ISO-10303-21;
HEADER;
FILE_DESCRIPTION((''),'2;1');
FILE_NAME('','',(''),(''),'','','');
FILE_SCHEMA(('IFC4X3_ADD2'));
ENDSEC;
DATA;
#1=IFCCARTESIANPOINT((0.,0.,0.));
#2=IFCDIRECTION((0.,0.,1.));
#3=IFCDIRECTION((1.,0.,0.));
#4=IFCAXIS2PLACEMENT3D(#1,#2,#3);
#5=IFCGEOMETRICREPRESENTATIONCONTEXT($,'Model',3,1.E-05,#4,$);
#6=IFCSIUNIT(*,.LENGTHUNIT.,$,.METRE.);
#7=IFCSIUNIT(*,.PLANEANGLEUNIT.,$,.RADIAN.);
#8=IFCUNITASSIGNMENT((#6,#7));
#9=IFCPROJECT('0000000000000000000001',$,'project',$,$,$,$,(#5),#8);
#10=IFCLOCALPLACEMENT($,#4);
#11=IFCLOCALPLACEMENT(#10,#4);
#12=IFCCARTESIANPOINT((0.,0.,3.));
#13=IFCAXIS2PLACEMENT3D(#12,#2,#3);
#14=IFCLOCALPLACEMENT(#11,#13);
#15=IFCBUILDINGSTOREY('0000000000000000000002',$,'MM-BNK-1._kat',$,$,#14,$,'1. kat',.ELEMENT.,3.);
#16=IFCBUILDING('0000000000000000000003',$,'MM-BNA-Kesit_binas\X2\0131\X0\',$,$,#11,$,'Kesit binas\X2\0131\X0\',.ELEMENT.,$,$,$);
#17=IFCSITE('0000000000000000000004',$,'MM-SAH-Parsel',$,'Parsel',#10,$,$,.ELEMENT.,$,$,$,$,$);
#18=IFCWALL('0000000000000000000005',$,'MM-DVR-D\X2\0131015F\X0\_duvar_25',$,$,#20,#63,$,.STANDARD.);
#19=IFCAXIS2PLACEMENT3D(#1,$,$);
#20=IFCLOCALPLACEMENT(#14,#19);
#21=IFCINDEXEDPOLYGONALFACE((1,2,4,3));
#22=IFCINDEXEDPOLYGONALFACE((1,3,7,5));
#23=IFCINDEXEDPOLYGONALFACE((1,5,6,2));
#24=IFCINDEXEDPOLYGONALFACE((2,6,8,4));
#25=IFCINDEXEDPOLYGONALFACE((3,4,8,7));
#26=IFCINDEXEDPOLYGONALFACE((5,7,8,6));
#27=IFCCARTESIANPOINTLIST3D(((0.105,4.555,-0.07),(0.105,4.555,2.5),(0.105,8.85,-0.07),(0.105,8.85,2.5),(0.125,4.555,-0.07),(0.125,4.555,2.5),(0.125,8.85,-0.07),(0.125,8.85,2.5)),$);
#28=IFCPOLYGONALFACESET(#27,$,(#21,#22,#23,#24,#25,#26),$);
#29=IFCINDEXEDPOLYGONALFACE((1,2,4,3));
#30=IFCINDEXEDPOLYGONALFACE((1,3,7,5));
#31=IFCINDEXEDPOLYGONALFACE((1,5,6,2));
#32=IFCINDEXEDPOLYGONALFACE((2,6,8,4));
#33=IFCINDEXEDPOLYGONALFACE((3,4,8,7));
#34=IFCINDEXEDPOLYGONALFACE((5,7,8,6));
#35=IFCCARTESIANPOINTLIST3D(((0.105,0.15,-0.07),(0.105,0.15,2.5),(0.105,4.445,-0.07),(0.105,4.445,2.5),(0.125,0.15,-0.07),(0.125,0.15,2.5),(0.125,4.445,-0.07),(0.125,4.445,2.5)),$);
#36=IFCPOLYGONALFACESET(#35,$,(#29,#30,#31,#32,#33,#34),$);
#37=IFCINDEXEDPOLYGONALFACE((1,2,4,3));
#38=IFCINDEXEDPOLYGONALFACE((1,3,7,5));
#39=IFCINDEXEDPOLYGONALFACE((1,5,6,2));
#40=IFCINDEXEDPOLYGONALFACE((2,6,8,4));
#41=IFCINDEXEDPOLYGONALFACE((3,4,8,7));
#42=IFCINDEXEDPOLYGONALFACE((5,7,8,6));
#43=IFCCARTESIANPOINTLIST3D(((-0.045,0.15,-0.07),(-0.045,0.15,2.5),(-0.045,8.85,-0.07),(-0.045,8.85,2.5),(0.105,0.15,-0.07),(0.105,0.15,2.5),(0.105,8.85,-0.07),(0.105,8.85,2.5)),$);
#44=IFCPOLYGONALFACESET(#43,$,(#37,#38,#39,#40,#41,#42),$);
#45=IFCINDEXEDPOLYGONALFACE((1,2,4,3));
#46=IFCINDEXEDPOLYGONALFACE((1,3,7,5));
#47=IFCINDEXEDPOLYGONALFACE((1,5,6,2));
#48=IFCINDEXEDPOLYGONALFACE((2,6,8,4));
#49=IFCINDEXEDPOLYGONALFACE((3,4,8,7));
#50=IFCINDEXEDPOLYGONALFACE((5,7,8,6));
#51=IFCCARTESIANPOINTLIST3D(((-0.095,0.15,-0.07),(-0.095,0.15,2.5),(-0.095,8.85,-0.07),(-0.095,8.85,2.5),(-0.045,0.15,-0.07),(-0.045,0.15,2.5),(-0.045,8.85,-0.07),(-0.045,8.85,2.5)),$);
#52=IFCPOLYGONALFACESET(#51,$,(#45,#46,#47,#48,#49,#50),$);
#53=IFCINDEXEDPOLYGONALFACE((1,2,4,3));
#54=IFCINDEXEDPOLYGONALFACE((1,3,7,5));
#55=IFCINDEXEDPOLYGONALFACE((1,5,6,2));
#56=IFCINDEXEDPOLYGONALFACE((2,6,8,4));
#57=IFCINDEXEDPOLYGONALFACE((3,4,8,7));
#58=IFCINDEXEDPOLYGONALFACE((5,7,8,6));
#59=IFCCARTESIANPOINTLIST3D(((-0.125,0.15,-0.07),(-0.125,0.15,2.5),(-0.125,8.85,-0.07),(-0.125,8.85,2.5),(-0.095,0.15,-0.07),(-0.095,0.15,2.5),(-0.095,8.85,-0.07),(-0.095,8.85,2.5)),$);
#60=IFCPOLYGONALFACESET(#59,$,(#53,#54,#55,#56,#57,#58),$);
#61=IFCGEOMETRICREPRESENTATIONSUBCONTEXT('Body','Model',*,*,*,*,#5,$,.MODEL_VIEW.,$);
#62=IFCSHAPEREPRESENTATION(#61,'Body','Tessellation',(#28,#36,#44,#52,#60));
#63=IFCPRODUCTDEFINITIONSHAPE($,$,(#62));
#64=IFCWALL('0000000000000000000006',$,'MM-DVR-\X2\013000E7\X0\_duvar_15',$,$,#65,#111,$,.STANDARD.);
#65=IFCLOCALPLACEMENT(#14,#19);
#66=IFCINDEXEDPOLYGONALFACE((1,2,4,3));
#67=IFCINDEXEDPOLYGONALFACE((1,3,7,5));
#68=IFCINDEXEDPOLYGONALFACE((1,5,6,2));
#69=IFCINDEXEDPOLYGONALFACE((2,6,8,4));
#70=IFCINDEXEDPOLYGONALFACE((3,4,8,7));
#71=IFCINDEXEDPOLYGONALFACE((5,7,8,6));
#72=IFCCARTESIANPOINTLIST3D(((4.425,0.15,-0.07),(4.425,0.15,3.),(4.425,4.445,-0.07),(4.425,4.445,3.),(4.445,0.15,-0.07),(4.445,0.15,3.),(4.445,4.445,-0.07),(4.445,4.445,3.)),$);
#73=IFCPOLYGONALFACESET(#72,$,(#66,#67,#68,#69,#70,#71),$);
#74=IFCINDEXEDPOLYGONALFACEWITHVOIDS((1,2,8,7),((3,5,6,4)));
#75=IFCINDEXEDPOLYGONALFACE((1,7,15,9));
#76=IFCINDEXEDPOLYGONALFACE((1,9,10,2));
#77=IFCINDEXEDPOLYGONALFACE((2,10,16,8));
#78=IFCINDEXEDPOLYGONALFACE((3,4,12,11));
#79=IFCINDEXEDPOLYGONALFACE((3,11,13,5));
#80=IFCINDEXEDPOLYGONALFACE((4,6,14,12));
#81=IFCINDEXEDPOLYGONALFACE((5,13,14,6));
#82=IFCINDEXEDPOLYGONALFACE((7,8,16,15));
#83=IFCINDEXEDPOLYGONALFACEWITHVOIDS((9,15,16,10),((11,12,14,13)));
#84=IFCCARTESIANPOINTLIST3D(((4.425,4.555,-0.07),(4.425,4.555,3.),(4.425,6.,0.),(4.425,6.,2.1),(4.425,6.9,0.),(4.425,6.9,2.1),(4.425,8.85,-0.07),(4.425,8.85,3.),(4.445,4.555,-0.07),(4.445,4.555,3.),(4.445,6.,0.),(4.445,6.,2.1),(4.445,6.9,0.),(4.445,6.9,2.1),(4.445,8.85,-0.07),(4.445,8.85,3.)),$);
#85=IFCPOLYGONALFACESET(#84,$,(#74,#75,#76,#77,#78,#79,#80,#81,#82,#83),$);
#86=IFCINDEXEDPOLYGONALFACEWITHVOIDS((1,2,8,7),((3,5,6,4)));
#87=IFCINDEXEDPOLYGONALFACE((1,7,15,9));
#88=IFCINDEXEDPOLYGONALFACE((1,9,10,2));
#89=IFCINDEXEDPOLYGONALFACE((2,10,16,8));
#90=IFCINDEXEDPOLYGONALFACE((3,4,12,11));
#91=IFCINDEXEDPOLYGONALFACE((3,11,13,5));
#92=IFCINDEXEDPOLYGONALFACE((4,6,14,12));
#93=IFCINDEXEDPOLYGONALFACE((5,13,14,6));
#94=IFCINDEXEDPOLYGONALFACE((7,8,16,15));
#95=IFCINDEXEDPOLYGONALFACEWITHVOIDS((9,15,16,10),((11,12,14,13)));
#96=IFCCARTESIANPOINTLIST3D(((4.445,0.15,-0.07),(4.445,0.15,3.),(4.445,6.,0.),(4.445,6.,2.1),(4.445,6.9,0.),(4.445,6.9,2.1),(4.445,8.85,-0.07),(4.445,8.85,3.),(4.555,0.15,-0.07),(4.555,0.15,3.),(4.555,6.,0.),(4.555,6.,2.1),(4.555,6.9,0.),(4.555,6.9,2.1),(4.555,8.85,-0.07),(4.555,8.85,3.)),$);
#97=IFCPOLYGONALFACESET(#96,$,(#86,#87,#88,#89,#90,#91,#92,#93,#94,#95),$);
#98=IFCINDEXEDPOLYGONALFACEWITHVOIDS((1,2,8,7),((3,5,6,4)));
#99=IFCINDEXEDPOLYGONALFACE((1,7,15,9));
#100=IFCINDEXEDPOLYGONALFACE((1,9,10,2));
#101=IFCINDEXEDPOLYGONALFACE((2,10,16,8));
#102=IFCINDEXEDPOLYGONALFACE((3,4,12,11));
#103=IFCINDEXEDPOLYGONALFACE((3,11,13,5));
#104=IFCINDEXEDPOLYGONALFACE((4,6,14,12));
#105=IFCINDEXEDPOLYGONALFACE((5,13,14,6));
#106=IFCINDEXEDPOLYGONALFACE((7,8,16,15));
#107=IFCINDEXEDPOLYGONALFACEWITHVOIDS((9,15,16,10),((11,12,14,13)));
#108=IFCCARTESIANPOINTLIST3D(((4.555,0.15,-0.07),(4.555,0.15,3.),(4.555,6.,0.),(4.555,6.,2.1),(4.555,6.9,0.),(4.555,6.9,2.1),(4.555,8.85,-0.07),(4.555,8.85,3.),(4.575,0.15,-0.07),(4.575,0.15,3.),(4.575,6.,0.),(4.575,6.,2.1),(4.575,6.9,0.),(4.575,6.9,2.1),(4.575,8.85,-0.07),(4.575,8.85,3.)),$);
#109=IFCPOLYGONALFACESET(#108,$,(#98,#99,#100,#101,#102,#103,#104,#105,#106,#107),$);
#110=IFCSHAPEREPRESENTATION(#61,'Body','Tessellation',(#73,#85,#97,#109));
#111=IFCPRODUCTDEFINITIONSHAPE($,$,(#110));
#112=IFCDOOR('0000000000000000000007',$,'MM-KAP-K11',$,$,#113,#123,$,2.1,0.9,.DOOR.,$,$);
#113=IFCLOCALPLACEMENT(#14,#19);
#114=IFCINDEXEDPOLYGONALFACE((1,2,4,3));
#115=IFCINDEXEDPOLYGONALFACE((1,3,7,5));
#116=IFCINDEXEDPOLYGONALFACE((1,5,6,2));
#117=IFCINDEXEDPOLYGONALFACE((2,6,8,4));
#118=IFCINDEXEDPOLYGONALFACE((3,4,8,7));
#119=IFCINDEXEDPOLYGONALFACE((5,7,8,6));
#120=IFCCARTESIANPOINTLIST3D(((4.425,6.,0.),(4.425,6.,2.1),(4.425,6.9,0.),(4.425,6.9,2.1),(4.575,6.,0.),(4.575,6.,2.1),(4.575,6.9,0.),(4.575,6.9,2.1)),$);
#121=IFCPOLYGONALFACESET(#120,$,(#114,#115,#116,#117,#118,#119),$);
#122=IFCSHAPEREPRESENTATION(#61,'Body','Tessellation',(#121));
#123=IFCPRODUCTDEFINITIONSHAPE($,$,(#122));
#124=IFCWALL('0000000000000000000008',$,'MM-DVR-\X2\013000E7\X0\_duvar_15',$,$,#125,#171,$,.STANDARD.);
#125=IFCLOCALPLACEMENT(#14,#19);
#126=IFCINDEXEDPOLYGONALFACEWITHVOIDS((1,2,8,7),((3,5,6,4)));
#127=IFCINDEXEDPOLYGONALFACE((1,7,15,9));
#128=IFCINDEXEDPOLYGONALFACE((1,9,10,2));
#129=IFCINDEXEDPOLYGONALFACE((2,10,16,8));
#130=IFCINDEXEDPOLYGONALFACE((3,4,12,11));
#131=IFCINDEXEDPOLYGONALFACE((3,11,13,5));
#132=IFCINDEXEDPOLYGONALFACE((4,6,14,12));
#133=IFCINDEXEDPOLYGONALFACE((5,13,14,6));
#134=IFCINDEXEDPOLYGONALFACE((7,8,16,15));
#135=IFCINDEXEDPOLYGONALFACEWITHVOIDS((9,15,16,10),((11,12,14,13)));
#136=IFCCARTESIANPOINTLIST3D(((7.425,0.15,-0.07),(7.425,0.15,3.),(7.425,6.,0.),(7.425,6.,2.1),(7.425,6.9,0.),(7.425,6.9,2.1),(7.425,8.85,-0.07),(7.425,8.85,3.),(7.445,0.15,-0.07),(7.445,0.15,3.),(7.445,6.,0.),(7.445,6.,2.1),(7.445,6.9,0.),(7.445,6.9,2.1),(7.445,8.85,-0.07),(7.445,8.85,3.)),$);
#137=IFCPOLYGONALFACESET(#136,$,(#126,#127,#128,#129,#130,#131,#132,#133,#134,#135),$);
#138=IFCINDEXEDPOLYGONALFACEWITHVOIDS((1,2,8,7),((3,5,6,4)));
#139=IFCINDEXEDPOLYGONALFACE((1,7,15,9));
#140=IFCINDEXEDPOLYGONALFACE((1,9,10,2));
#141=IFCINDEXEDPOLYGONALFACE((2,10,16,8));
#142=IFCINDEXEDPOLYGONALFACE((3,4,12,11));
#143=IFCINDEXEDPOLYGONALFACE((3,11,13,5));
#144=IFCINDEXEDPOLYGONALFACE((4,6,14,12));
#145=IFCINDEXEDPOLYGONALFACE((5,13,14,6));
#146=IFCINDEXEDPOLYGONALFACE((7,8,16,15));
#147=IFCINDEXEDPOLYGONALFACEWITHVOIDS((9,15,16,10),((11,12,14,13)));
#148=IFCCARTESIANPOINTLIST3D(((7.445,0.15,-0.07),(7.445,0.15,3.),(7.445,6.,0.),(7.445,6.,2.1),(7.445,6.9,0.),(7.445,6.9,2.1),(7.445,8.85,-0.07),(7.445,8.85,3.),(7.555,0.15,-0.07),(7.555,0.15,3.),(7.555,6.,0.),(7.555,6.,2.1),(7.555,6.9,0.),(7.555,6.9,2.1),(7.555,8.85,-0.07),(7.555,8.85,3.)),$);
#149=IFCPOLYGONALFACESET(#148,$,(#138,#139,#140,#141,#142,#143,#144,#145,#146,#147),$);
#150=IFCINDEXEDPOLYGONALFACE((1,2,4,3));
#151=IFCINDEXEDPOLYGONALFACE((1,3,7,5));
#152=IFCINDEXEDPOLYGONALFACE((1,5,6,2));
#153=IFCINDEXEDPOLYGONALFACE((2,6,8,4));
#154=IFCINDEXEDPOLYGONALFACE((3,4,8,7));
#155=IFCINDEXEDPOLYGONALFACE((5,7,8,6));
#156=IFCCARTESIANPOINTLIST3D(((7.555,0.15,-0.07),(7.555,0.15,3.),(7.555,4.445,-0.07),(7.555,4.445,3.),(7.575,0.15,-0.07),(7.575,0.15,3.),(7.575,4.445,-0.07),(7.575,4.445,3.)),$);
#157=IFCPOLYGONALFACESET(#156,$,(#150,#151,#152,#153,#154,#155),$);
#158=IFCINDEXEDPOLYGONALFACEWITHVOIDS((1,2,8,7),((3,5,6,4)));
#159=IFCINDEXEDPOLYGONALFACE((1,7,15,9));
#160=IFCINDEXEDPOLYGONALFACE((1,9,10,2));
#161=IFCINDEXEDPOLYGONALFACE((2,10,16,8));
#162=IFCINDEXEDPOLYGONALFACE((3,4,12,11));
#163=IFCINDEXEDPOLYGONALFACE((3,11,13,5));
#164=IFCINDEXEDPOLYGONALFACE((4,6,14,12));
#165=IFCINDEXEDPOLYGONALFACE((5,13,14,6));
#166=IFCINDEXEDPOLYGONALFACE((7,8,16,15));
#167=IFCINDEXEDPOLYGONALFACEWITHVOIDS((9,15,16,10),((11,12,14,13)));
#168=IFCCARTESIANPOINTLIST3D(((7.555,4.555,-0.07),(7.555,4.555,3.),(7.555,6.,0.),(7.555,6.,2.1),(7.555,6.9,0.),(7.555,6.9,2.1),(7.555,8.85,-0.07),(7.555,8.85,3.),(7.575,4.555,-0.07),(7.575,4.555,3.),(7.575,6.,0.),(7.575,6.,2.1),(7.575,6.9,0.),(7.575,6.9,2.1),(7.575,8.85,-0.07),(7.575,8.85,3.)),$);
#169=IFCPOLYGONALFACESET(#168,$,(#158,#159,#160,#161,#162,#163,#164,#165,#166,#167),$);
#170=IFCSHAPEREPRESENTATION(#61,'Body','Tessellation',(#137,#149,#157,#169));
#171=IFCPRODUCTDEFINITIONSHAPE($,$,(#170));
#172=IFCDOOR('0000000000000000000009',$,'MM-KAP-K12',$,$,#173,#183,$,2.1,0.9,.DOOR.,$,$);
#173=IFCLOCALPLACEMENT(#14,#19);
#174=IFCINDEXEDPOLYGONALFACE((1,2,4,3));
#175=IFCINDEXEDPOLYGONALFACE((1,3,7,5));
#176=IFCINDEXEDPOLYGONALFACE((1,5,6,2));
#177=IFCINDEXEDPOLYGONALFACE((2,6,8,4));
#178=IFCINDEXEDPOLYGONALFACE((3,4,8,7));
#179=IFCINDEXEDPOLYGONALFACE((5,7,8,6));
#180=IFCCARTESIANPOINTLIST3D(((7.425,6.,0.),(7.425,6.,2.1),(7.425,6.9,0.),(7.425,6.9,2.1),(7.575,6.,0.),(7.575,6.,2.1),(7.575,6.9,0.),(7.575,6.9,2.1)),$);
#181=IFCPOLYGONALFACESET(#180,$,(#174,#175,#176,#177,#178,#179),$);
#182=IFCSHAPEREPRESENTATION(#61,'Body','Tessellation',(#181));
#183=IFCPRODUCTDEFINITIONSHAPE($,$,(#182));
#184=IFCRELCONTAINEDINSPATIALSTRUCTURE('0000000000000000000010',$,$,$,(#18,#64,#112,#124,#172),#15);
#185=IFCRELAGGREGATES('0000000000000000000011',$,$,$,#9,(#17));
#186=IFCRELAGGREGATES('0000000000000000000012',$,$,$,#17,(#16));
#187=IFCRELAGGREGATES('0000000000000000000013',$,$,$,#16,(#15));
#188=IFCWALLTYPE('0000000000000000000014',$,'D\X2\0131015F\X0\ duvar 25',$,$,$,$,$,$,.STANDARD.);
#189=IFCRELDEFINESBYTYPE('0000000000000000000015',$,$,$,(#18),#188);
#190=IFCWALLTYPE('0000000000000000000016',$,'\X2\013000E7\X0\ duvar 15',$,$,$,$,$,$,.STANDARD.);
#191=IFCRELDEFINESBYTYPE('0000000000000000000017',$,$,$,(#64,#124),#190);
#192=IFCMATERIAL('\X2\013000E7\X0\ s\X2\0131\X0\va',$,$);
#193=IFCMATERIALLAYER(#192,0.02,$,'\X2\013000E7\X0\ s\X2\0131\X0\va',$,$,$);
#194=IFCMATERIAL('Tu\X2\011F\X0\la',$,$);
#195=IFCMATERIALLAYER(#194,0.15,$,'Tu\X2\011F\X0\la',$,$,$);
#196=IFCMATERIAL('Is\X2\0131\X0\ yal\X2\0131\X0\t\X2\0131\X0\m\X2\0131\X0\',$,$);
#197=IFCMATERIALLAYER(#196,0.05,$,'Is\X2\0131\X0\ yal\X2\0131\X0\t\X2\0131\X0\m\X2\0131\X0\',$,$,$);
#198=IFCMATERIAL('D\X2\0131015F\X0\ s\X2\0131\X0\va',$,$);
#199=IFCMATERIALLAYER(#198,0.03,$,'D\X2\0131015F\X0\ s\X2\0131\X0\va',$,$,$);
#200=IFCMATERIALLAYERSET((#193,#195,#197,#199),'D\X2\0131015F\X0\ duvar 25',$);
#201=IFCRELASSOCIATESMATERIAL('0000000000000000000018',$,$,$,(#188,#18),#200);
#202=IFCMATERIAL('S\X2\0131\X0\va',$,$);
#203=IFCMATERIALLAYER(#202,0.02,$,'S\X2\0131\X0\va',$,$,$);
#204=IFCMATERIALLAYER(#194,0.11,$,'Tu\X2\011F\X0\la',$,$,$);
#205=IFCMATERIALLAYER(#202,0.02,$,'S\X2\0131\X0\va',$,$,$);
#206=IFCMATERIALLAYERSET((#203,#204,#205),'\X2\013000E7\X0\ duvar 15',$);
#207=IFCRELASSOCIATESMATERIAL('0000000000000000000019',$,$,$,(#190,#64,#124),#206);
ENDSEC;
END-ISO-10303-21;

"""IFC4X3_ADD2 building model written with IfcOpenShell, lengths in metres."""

from ifc_helpers import new_model, si_unit, frame, origin, origin_with_axes, place, context, subcontext, project, spatial, polyline, outline, extrude, material, layer, layer_set, type_object, element, fill, save


model = new_model("IFC4X3_ADD2")

# Units and contexts
model_context = context("Model", 3, precision=1e-05, world=origin_with_axes())
body_context = subcontext(model_context, "Body", "Model", "MODEL_VIEW")
ifc_project = project(units=[si_unit("LENGTHUNIT", "METRE"), si_unit("PLANEANGLEUNIT", "RADIAN")], contexts=[model_context])

# Site, building, storey
site_placement = place(None, origin_with_axes())
site = spatial("IfcSite", under=ifc_project, at=site_placement, Name="MM-SAH-Parsel", ObjectType="Parsel", CompositionType="ELEMENT")
building_placement = place(site_placement, origin_with_axes())
building = spatial("IfcBuilding", under=site, at=building_placement, Name="MM-BNA-Kesit_binası", LongName="Kesit binası", CompositionType="ELEMENT")
storey_placement = place(building_placement, frame((0.0, 0.0, 3.0), z_axis=(0.0, 0.0, 1.0), x_axis=(1.0, 0.0, 0.0)))
storey = spatial("IfcBuildingStorey", under=building, at=storey_placement, Name="MM-BNK-1._kat", LongName="1. kat", CompositionType="ELEMENT", Elevation=3.0)

# Shared definitions
ifc_material_1 = material(Name="İç sıva")
ifc_layer_1 = layer(ifc_material_1, 0.02, Name="İç sıva")
ifc_material_2 = material(Name="Tuğla")
ifc_layer_2 = layer(ifc_material_2, 0.15, Name="Tuğla")
ifc_material_3 = material(Name="Isı yalıtımı")
ifc_layer_3 = layer(ifc_material_3, 0.05, Name="Isı yalıtımı")
ifc_material_4 = material(Name="Dış sıva")
ifc_layer_4 = layer(ifc_material_4, 0.03, Name="Dış sıva")
ifc_layer_set_1 = layer_set([ifc_layer_1, ifc_layer_2, ifc_layer_3, ifc_layer_4], Name="Dış duvar 25")
wall_type_1 = type_object("IfcWallType", Name="Dış duvar 25", PredefinedType="STANDARD", material=ifc_layer_set_1)

# Wall
wall_1_placement = place(storey_placement, origin_with_axes())
element("IfcWall", 1, at=wall_1_placement, inside=storey, type_object=wall_type_1, material=ifc_layer_set_1, Name="MM-DVR-Dış_duvar_25", PredefinedType="STANDARD", context=body_context, shape_type="SweptSolid", body=[
    extrude(outline(polyline([(0.105, 8.85), (0.105, 4.555), (0.125, 4.555), (0.125, 8.85), (0.105, 8.85)])), frame((0.0, 0.0, -0.07)), (0.0, 0.0, 1.0), 2.57),
    extrude(outline(polyline([(0.105, 4.445), (0.105, 0.15), (0.125, 0.15), (0.125, 4.445), (0.105, 4.445)])), frame((0.0, 0.0, -0.07)), (0.0, 0.0, 1.0), 2.57),
    extrude(outline(polyline([(-0.045, 8.85), (-0.045, 0.15), (0.105, 0.15), (0.105, 8.85), (-0.045, 8.85)])), frame((0.0, 0.0, -0.07)), (0.0, 0.0, 1.0), 2.57),
    extrude(outline(polyline([(-0.095, 8.85), (-0.095, 0.15), (-0.045, 0.15), (-0.045, 8.85), (-0.095, 8.85)])), frame((0.0, 0.0, -0.07)), (0.0, 0.0, 1.0), 2.57),
    extrude(outline(polyline([(-0.125, 8.85), (-0.125, 0.15), (-0.095, 0.15), (-0.095, 8.85), (-0.125, 8.85)])), frame((0.0, 0.0, -0.07)), (0.0, 0.0, 1.0), 2.57),
])

# Walls, openings, doors
ifc_material_5 = material(Name="Sıva")
ifc_layer_5 = layer(ifc_material_5, 0.02, Name="Sıva")
ifc_layer_6 = layer(ifc_material_2, 0.11, Name="Tuğla")
ifc_layer_7 = layer(ifc_material_5, 0.02, Name="Sıva")
ifc_layer_set_2 = layer_set([ifc_layer_5, ifc_layer_6, ifc_layer_7], Name="İç duvar 15")
wall_type_2 = type_object("IfcWallType", Name="İç duvar 15", PredefinedType="STANDARD", material=ifc_layer_set_2)
wall_2_placement = place(storey_placement, origin_with_axes())
wall_2 = element("IfcWall", 2, at=wall_2_placement, inside=storey, type_object=wall_type_2, material=ifc_layer_set_2, Name="MM-DVR-İç_duvar_15", PredefinedType="STANDARD", context=body_context, shape_type="SweptSolid", body=[
    extrude(outline(polyline([(4.445, 0.15), (4.445, 4.445), (4.425, 4.445), (4.425, 0.15), (4.445, 0.15)])), frame((0.0, 0.0, -0.07)), (0.0, 0.0, 1.0), 3.07),
    extrude(outline(polyline([(4.445, 4.555), (4.445, 8.85), (4.425, 8.85), (4.425, 4.555), (4.445, 4.555)])), frame((0.0, 0.0, -0.07)), (0.0, 0.0, 1.0), 3.07),
    extrude(outline(polyline([(4.555, 0.15), (4.555, 8.85), (4.445, 8.85), (4.445, 0.15), (4.555, 0.15)])), frame((0.0, 0.0, -0.07)), (0.0, 0.0, 1.0), 3.07),
    extrude(outline(polyline([(4.575, 0.15), (4.575, 8.85), (4.555, 8.85), (4.555, 0.15), (4.575, 0.15)])), frame((0.0, 0.0, -0.07)), (0.0, 0.0, 1.0), 3.07),
])
opening_1_placement = place(storey_placement, origin_with_axes())
opening_1 = element("IfcOpeningElement", 3, at=opening_1_placement, cuts=wall_2, PredefinedType="OPENING", context=body_context, shape_type="SweptSolid", body=[
    extrude(outline(polyline([(4.425, 6.0), (4.425, 6.9), (4.575, 6.9), (4.575, 6.0), (4.425, 6.0)])), origin(), (0.0, 0.0, 1.0), 2.1),
])
door_1_placement = place(storey_placement, origin_with_axes())
door_1 = element("IfcDoor", 4, at=door_1_placement, inside=storey, Name="MM-KAP-K11", OverallHeight=2.1, OverallWidth=0.9, PredefinedType="DOOR", context=body_context, shape_type="SweptSolid", body=[
    extrude(outline(polyline([(4.425, 6.0), (4.425, 6.9), (4.575, 6.9), (4.575, 6.0), (4.425, 6.0)])), origin(), (0.0, 0.0, 1.0), 2.1),
])
fill(opening_1, door_1)
wall_3_placement = place(storey_placement, origin_with_axes())
wall_3 = element("IfcWall", 5, at=wall_3_placement, inside=storey, type_object=wall_type_2, material=ifc_layer_set_2, Name="MM-DVR-İç_duvar_15", PredefinedType="STANDARD", context=body_context, shape_type="SweptSolid", body=[
    extrude(outline(polyline([(7.445, 0.15), (7.445, 8.85), (7.425, 8.85), (7.425, 0.15), (7.445, 0.15)])), frame((0.0, 0.0, -0.07)), (0.0, 0.0, 1.0), 3.07),
    extrude(outline(polyline([(7.555, 0.15), (7.555, 8.85), (7.445, 8.85), (7.445, 0.15), (7.555, 0.15)])), frame((0.0, 0.0, -0.07)), (0.0, 0.0, 1.0), 3.07),
    extrude(outline(polyline([(7.575, 0.15), (7.575, 4.445), (7.555, 4.445), (7.555, 0.15), (7.575, 0.15)])), frame((0.0, 0.0, -0.07)), (0.0, 0.0, 1.0), 3.07),
    extrude(outline(polyline([(7.575, 4.555), (7.575, 8.85), (7.555, 8.85), (7.555, 4.555), (7.575, 4.555)])), frame((0.0, 0.0, -0.07)), (0.0, 0.0, 1.0), 3.07),
])
opening_2_placement = place(storey_placement, origin_with_axes())
opening_2 = element("IfcOpeningElement", 6, at=opening_2_placement, cuts=wall_3, PredefinedType="OPENING", context=body_context, shape_type="SweptSolid", body=[
    extrude(outline(polyline([(7.425, 6.0), (7.425, 6.9), (7.575, 6.9), (7.575, 6.0), (7.425, 6.0)])), origin(), (0.0, 0.0, 1.0), 2.1),
])
door_2_placement = place(storey_placement, origin_with_axes())
door_2 = element("IfcDoor", 7, at=door_2_placement, inside=storey, Name="MM-KAP-K12", OverallHeight=2.1, OverallWidth=0.9, PredefinedType="DOOR", context=body_context, shape_type="SweptSolid", body=[
    extrude(outline(polyline([(7.425, 6.0), (7.425, 6.9), (7.575, 6.9), (7.575, 6.0), (7.425, 6.0)])), origin(), (0.0, 0.0, 1.0), 2.1),
])
fill(opening_2, door_2)

save(model, "model.ifc")
